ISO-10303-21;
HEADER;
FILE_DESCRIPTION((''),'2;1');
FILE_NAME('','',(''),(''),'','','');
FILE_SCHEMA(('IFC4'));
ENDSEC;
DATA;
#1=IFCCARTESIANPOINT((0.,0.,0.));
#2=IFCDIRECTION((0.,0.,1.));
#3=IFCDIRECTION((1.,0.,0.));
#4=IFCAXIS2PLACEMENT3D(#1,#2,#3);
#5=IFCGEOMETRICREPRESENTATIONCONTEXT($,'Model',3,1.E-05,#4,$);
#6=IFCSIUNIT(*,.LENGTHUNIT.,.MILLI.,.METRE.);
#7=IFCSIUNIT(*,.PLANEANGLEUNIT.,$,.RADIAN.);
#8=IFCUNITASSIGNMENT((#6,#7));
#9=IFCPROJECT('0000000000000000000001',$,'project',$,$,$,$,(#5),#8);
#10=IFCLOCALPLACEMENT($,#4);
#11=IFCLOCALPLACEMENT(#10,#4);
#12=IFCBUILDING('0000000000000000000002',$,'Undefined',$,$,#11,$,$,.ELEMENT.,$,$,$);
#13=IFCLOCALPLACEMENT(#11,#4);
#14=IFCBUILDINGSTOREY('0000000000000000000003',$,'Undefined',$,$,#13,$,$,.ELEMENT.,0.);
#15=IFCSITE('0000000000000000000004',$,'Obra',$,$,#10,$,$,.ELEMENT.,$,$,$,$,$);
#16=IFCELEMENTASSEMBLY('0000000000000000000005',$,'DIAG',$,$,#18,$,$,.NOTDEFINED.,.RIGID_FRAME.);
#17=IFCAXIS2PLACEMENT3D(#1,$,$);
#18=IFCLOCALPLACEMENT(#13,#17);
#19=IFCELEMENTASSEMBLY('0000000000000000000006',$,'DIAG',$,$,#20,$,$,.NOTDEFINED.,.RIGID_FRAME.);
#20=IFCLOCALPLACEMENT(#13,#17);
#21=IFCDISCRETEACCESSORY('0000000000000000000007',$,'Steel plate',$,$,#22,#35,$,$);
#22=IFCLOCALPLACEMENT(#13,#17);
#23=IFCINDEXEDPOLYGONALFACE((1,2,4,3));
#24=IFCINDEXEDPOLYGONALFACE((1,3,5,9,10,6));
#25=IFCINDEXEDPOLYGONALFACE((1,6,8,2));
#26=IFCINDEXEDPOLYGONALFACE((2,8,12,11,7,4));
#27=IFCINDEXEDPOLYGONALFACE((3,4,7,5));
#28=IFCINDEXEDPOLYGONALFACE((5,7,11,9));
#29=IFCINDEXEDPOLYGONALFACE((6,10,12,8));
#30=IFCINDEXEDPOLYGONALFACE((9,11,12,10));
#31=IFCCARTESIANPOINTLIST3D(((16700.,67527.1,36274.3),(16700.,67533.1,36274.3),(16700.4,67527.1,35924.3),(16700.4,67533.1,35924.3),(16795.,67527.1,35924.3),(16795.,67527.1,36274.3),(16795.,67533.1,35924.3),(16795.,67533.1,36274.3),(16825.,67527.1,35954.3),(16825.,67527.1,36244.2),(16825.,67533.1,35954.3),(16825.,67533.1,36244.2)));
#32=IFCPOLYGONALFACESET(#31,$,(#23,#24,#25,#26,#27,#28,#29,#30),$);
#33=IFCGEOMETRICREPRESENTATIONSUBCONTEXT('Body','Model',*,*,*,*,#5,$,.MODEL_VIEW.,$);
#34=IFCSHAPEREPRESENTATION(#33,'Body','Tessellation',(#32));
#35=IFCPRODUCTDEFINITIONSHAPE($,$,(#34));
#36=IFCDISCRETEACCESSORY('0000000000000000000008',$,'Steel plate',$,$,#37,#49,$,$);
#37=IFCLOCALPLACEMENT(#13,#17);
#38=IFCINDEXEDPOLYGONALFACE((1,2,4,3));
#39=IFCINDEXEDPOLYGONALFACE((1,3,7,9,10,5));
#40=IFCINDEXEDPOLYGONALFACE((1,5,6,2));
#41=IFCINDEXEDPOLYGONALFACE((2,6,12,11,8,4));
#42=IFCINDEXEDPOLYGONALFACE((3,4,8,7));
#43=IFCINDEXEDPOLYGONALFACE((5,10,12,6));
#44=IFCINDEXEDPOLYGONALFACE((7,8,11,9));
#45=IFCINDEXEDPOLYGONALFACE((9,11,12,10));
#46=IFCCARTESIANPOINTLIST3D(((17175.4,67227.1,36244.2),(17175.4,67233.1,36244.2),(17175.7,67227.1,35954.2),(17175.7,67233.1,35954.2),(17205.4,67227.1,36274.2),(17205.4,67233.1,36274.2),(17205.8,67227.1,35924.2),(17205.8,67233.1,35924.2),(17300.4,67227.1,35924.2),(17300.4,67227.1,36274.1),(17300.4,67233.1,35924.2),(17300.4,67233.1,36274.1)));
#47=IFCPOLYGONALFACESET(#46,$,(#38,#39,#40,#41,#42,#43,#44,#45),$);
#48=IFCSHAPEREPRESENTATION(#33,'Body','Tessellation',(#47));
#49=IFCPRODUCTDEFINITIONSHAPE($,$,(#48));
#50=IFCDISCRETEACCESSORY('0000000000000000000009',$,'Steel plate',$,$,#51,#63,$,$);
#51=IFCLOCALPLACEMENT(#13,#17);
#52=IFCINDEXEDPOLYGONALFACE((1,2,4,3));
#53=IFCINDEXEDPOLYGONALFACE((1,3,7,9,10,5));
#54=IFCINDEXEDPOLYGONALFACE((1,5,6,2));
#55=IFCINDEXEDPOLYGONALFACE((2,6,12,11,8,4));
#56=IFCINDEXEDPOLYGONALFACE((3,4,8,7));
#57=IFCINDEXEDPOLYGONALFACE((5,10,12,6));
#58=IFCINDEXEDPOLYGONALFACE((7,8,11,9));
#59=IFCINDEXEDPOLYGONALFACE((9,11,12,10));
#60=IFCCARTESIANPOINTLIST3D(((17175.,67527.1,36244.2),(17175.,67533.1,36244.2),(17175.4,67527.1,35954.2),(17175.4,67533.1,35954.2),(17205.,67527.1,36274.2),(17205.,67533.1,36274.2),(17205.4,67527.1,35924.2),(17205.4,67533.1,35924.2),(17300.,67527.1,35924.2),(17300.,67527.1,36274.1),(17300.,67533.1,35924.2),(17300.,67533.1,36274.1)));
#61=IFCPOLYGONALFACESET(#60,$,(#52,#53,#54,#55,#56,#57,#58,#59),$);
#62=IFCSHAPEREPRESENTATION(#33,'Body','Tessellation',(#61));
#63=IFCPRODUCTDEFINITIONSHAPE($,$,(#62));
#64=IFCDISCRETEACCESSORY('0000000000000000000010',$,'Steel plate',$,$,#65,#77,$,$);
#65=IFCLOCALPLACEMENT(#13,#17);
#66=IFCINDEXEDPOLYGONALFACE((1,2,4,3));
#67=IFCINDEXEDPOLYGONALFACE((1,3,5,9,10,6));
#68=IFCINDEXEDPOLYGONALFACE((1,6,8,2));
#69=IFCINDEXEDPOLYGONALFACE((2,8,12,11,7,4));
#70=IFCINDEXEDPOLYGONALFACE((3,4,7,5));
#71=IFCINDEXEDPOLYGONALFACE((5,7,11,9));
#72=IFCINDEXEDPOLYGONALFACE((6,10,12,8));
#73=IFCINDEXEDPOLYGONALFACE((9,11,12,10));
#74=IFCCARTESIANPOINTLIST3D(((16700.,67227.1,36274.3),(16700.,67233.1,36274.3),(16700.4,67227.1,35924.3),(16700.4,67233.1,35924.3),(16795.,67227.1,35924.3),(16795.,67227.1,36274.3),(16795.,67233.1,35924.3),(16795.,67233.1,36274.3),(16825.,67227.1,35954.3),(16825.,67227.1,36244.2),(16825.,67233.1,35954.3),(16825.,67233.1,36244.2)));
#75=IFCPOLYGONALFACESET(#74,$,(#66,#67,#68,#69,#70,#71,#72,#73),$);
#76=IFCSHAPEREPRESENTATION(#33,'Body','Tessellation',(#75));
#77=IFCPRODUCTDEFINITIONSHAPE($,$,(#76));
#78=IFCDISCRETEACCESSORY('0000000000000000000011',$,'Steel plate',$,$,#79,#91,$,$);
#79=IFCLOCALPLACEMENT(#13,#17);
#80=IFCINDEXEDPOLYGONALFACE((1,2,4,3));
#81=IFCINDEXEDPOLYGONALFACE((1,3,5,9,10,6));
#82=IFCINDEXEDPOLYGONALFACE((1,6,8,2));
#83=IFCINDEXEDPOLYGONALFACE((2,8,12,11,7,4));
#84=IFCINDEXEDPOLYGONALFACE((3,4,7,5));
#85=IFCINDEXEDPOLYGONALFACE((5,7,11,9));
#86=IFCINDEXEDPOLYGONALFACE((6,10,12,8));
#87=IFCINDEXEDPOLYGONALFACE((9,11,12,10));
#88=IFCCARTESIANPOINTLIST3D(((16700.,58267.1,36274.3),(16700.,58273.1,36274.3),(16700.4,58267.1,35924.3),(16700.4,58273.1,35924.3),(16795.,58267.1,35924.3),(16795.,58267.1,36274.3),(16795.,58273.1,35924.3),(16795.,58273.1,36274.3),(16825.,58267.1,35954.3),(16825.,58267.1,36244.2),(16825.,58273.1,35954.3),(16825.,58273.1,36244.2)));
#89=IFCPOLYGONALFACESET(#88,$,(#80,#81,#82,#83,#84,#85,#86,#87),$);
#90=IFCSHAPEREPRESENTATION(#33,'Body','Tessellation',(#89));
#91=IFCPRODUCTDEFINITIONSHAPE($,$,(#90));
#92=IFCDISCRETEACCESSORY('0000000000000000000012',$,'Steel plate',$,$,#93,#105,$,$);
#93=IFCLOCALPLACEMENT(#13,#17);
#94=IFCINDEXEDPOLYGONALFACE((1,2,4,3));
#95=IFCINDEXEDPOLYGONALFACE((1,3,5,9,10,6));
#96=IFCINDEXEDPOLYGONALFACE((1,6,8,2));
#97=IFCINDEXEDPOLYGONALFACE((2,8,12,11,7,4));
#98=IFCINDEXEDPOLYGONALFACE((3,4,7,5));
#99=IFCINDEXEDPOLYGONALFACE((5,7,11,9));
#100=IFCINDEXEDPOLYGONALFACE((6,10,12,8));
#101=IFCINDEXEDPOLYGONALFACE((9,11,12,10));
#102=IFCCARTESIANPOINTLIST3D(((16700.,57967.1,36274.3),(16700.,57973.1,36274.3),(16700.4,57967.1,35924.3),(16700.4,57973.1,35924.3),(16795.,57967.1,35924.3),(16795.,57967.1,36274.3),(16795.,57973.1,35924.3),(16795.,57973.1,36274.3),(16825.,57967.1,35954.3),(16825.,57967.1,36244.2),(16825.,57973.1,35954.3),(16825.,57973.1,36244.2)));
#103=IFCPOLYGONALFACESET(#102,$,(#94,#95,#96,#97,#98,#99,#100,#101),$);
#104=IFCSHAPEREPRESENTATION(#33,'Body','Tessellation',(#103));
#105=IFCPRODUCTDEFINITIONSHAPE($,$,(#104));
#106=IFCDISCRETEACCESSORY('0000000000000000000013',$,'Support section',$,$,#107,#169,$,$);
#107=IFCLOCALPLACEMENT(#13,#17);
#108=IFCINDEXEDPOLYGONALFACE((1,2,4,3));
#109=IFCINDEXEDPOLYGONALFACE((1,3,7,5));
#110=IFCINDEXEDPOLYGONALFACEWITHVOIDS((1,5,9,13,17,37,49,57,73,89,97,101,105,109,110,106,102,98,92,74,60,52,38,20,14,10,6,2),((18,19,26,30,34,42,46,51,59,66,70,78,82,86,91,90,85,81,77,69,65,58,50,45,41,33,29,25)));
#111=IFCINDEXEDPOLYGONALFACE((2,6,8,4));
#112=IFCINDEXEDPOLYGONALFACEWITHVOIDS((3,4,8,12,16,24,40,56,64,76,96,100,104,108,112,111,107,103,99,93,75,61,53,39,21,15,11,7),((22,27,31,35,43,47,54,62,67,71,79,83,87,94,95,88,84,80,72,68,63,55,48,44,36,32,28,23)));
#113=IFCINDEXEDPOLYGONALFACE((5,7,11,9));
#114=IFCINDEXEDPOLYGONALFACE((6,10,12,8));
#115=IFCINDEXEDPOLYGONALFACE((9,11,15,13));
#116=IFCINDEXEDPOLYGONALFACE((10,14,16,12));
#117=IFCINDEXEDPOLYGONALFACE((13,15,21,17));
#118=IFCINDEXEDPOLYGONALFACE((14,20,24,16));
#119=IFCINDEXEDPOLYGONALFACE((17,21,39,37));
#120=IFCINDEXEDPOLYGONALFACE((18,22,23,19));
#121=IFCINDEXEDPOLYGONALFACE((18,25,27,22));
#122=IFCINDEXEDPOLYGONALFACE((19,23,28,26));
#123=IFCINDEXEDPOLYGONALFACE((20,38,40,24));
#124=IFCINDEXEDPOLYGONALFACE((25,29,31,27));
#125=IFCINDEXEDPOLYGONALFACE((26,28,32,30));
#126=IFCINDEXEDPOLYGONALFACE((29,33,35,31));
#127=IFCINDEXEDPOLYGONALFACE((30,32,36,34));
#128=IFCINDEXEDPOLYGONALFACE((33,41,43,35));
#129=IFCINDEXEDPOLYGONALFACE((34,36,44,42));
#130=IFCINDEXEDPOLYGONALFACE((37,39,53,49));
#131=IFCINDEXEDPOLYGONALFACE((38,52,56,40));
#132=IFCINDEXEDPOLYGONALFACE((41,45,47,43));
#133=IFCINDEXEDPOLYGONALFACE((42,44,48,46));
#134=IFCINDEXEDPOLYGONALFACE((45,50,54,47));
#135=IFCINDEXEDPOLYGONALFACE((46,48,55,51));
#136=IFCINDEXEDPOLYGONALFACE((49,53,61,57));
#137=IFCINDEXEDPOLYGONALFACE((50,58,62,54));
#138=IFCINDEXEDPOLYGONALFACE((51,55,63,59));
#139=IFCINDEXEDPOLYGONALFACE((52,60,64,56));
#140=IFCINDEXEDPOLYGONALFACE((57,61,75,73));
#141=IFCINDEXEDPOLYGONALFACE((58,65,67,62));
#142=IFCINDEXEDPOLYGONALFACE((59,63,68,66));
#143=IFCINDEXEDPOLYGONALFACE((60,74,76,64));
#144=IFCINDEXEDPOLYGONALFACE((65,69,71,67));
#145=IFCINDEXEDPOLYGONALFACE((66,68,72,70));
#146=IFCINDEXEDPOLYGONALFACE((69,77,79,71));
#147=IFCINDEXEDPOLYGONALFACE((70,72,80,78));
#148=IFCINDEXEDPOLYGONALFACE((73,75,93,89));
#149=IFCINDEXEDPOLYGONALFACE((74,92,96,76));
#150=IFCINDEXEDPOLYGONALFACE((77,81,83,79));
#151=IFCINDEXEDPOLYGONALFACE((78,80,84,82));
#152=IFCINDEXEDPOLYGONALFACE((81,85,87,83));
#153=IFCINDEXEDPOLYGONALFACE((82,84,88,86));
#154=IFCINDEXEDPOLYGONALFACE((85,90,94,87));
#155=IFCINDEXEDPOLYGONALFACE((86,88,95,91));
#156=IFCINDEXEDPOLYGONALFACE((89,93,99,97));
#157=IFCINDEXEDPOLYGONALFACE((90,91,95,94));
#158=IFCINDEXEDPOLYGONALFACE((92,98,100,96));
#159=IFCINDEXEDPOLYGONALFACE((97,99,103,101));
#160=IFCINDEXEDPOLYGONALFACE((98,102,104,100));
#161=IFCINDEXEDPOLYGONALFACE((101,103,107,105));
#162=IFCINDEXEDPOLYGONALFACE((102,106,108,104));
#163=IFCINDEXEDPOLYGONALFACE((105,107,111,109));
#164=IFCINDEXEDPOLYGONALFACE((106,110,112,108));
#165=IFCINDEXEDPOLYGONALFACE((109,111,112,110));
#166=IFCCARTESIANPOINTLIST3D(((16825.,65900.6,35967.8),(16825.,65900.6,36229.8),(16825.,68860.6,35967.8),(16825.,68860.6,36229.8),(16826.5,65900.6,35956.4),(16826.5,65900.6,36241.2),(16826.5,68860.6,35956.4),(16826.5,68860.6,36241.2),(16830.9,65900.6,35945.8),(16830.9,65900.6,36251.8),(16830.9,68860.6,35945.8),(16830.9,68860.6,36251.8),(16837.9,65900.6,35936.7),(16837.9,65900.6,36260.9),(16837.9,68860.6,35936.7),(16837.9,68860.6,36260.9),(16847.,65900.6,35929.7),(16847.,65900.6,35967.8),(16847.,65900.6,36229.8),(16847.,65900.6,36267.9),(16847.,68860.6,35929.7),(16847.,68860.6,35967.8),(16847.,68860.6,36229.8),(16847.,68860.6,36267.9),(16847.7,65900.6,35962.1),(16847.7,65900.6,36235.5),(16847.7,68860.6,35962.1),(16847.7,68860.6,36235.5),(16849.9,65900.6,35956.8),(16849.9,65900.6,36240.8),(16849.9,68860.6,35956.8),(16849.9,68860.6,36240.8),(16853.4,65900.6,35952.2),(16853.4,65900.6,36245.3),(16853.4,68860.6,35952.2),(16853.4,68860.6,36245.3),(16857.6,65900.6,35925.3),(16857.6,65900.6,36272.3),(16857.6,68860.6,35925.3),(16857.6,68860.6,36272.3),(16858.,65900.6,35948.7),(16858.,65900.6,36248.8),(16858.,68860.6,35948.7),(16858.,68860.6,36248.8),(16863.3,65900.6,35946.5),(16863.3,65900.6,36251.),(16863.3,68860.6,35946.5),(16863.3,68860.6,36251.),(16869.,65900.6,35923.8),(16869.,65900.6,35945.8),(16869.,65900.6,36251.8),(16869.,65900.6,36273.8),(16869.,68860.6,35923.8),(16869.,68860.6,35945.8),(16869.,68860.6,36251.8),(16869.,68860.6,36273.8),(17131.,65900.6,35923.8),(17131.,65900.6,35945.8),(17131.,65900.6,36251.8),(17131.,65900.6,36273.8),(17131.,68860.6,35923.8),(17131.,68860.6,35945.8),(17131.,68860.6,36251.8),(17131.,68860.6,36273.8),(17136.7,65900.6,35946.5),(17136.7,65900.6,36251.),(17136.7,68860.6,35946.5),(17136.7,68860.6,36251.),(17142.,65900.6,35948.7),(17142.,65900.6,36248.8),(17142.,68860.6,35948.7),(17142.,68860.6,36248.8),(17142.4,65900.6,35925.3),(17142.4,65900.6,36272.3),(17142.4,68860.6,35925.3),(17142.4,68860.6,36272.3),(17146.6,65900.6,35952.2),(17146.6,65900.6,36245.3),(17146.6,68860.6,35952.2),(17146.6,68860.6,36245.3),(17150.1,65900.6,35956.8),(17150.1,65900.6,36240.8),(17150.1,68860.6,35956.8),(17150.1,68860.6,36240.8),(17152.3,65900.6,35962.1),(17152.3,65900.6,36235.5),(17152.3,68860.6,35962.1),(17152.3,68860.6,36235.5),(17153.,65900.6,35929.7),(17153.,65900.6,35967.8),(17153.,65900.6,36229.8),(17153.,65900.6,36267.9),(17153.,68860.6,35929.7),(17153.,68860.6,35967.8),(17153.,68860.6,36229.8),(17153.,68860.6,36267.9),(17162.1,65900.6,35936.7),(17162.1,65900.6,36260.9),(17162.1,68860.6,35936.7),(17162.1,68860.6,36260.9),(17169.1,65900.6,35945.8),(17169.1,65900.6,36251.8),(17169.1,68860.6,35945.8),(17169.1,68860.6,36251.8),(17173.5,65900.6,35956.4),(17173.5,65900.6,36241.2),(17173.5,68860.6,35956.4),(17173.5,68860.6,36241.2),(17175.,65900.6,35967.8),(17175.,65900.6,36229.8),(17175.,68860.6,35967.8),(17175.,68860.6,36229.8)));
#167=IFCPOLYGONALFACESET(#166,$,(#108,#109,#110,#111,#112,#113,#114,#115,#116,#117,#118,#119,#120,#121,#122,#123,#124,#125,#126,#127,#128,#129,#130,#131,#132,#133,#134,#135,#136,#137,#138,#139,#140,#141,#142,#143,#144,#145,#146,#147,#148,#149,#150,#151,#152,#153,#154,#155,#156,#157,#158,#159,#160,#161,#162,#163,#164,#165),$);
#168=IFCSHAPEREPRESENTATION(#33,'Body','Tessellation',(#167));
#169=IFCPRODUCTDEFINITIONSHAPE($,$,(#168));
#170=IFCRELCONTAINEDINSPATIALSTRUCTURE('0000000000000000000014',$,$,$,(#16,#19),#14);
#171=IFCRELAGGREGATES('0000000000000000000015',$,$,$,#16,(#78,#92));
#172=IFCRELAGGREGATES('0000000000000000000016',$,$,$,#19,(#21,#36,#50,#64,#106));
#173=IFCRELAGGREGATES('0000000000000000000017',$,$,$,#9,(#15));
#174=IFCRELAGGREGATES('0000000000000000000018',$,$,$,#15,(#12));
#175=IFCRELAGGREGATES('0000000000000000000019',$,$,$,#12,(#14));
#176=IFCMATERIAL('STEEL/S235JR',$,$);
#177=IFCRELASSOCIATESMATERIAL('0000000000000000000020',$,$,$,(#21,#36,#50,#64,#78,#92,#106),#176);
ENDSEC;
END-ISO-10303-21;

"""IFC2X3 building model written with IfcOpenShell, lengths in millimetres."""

from ifc_helpers import new_model, si_unit, frame, origin_with_axes, origin_2d_with_axis, place, context, subcontext, project, spatial, polyline, hollow_rectangle, outline, extrude, clip, halfspace, material, element, aggregate, save


model = new_model("IFC2X3")

# Units and contexts
model_context = context("Model", 3, precision=1e-05, world=origin_with_axes())
body_context = subcontext(model_context, "Body", "Model", "MODEL_VIEW")
ifc_project = project(units=[si_unit("LENGTHUNIT", "METRE", prefix="MILLI"), si_unit("PLANEANGLEUNIT", "RADIAN")], contexts=[model_context])

# Site, building, storey
site_placement = place(None, origin_with_axes())
site = spatial("IfcSite", under=ifc_project, at=site_placement, Name="Obra", CompositionType="ELEMENT")
building_placement = place(site_placement, origin_with_axes())
building = spatial("IfcBuilding", under=site, at=building_placement, Name="Undefined", CompositionType="ELEMENT")
storey_placement = place(building_placement, origin_with_axes())
storey = spatial("IfcBuildingStorey", under=building, at=storey_placement, Name="Undefined", CompositionType="ELEMENT", Elevation=0.0)

# Element assemblies
assembly_1_placement = place(storey_placement, origin_with_axes())
assembly_1 = element("IfcElementAssembly", 1, at=assembly_1_placement, inside=storey, Name="DIAG", AssemblyPlace="NOTDEFINED", PredefinedType="RIGID_FRAME")
ifc_material_1 = material(Name="STEEL/S235JR")
assembly_2_placement = place(storey_placement, origin_with_axes())
assembly_2 = element("IfcElementAssembly", 2, at=assembly_2_placement, inside=storey, Name="DIAG", AssemblyPlace="NOTDEFINED", PredefinedType="RIGID_FRAME")

# Discrete accessories
discrete_accessory_1_placement = place(assembly_2_placement, frame((16825.0, 67530.1, 35924.3), z_axis=(0.0, 1.0, 0.0), x_axis=(-1.0, 0.0, 0.0)))
discrete_accessory_1 = element("IfcDiscreteAccessory", 3, at=discrete_accessory_1_placement, material=ifc_material_1, Name="Steel plate", context=body_context, shape_type="SweptSolid", body=[
    extrude(outline(polyline([(0.0, 30.0), (30.0, 0.0), (124.6, 0.0), (125.0, 350.0), (30.0, 349.9), (0.0, 319.9), (0.0, 30.0)])), frame((0.0, 0.0, -3.0), z_axis=(0.0, 0.0, 1.0), x_axis=(1.0, 0.0, 0.0)), (0.0, 0.0, 1.0), 6.0),
])
discrete_accessory_2_placement = place(assembly_2_placement, frame((17300.4, 67230.1, 35924.2), z_axis=(0.0, 1.0, 0.0), x_axis=(-1.0, 0.0, 0.0)))
discrete_accessory_2 = element("IfcDiscreteAccessory", 4, at=discrete_accessory_2_placement, material=ifc_material_1, Name="Steel plate", context=body_context, shape_type="SweptSolid", body=[
    extrude(outline(polyline([(0.0, 0.0), (94.6, 0.0), (124.6, 30.0), (125.0, 320.0), (95.0, 350.0), (0.0, 349.9), (0.0, 0.0)])), frame((0.0, 0.0, -3.0), z_axis=(0.0, 0.0, 1.0), x_axis=(1.0, 0.0, 0.0)), (0.0, 0.0, 1.0), 6.0),
])
discrete_accessory_3_placement = place(assembly_2_placement, frame((17300.0, 67530.1, 35924.2), z_axis=(0.0, 1.0, 0.0), x_axis=(-1.0, 0.0, 0.0)))
discrete_accessory_3 = element("IfcDiscreteAccessory", 5, at=discrete_accessory_3_placement, material=ifc_material_1, Name="Steel plate", context=body_context, shape_type="SweptSolid", body=[
    extrude(outline(polyline([(0.0, 0.0), (94.6, 0.0), (124.6, 30.0), (125.0, 320.0), (95.0, 350.0), (0.0, 349.9), (0.0, 0.0)])), frame((0.0, 0.0, -3.0), z_axis=(0.0, 0.0, 1.0), x_axis=(1.0, 0.0, 0.0)), (0.0, 0.0, 1.0), 6.0),
])
discrete_accessory_4_placement = place(assembly_2_placement, frame((16825.0, 67230.1, 35924.3), z_axis=(0.0, 1.0, 0.0), x_axis=(-1.0, 0.0, 0.0)))
discrete_accessory_4 = element("IfcDiscreteAccessory", 6, at=discrete_accessory_4_placement, material=ifc_material_1, Name="Steel plate", context=body_context, shape_type="SweptSolid", body=[
    extrude(outline(polyline([(0.0, 30.0), (30.0, 0.0), (124.6, 0.0), (125.0, 350.0), (30.0, 349.9), (0.0, 319.9), (0.0, 30.0)])), frame((0.0, 0.0, -3.0), z_axis=(0.0, 0.0, 1.0), x_axis=(1.0, 0.0, 0.0)), (0.0, 0.0, 1.0), 6.0),
])
discrete_accessory_5_placement = place(assembly_1_placement, frame((16825.0, 58270.1, 35924.3), z_axis=(0.0, 1.0, 0.0), x_axis=(-1.0, 0.0, 0.0)))
discrete_accessory_5 = element("IfcDiscreteAccessory", 7, at=discrete_accessory_5_placement, material=ifc_material_1, Name="Steel plate", context=body_context, shape_type="SweptSolid", body=[
    extrude(outline(polyline([(0.0, 30.0), (30.0, 0.0), (124.6, 0.0), (125.0, 350.0), (30.0, 349.9), (0.0, 319.9), (0.0, 30.0)])), frame((0.0, 0.0, -3.0), z_axis=(0.0, 0.0, 1.0), x_axis=(1.0, 0.0, 0.0)), (0.0, 0.0, 1.0), 6.0),
])
discrete_accessory_6_placement = place(assembly_1_placement, frame((16825.0, 57970.1, 35924.3), z_axis=(0.0, 1.0, 0.0), x_axis=(-1.0, 0.0, 0.0)))
discrete_accessory_6 = element("IfcDiscreteAccessory", 8, at=discrete_accessory_6_placement, material=ifc_material_1, Name="Steel plate", context=body_context, shape_type="SweptSolid", body=[
    extrude(outline(polyline([(0.0, 30.0), (30.0, 0.0), (124.6, 0.0), (125.0, 350.0), (30.0, 349.9), (0.0, 319.9), (0.0, 30.0)])), frame((0.0, 0.0, -3.0), z_axis=(0.0, 0.0, 1.0), x_axis=(1.0, 0.0, 0.0)), (0.0, 0.0, 1.0), 6.0),
])

aggregate(assembly_1, [discrete_accessory_5, discrete_accessory_6])

# Discrete accessory
discrete_accessory_7_placement = place(assembly_2_placement, frame((17000.0, 65880.6, 36098.8), z_axis=(0.0, 0.0, 1.0), x_axis=(0.0, 1.0, 0.0)))
discrete_accessory_7 = element("IfcDiscreteAccessory", 9, at=discrete_accessory_7_placement, material=ifc_material_1, Name="Support section", context=body_context, shape_type="Clipping", body=[
    clip(clip(extrude(hollow_rectangle(XDim=350.0, YDim=350.0, WallThickness=22.0, InnerFilletRadius=22.0, OuterFilletRadius=44.0, at=origin_2d_with_axis()), frame((2980.0, 0.0, 0.0), z_axis=(-1.0, 0.0, 0.0), x_axis=(0.0, -1.0, 0.0)), (0.0, 0.0, 1.0), 2960.1), halfspace(frame((2980.1, 0.0, -1000.0), z_axis=(-1.0, 0.0, -0.000097), x_axis=(0.0, 1.0, 0.0)), True)), halfspace(frame((20.0, 0.0, -175.0), z_axis=(1.0, 0.0, -0.000056), x_axis=(0.0, -1.0, 0.0)), True)),
])
aggregate(assembly_2, [discrete_accessory_1, discrete_accessory_2, discrete_accessory_3, discrete_accessory_4, discrete_accessory_7])

save(model, "model.ifc")
